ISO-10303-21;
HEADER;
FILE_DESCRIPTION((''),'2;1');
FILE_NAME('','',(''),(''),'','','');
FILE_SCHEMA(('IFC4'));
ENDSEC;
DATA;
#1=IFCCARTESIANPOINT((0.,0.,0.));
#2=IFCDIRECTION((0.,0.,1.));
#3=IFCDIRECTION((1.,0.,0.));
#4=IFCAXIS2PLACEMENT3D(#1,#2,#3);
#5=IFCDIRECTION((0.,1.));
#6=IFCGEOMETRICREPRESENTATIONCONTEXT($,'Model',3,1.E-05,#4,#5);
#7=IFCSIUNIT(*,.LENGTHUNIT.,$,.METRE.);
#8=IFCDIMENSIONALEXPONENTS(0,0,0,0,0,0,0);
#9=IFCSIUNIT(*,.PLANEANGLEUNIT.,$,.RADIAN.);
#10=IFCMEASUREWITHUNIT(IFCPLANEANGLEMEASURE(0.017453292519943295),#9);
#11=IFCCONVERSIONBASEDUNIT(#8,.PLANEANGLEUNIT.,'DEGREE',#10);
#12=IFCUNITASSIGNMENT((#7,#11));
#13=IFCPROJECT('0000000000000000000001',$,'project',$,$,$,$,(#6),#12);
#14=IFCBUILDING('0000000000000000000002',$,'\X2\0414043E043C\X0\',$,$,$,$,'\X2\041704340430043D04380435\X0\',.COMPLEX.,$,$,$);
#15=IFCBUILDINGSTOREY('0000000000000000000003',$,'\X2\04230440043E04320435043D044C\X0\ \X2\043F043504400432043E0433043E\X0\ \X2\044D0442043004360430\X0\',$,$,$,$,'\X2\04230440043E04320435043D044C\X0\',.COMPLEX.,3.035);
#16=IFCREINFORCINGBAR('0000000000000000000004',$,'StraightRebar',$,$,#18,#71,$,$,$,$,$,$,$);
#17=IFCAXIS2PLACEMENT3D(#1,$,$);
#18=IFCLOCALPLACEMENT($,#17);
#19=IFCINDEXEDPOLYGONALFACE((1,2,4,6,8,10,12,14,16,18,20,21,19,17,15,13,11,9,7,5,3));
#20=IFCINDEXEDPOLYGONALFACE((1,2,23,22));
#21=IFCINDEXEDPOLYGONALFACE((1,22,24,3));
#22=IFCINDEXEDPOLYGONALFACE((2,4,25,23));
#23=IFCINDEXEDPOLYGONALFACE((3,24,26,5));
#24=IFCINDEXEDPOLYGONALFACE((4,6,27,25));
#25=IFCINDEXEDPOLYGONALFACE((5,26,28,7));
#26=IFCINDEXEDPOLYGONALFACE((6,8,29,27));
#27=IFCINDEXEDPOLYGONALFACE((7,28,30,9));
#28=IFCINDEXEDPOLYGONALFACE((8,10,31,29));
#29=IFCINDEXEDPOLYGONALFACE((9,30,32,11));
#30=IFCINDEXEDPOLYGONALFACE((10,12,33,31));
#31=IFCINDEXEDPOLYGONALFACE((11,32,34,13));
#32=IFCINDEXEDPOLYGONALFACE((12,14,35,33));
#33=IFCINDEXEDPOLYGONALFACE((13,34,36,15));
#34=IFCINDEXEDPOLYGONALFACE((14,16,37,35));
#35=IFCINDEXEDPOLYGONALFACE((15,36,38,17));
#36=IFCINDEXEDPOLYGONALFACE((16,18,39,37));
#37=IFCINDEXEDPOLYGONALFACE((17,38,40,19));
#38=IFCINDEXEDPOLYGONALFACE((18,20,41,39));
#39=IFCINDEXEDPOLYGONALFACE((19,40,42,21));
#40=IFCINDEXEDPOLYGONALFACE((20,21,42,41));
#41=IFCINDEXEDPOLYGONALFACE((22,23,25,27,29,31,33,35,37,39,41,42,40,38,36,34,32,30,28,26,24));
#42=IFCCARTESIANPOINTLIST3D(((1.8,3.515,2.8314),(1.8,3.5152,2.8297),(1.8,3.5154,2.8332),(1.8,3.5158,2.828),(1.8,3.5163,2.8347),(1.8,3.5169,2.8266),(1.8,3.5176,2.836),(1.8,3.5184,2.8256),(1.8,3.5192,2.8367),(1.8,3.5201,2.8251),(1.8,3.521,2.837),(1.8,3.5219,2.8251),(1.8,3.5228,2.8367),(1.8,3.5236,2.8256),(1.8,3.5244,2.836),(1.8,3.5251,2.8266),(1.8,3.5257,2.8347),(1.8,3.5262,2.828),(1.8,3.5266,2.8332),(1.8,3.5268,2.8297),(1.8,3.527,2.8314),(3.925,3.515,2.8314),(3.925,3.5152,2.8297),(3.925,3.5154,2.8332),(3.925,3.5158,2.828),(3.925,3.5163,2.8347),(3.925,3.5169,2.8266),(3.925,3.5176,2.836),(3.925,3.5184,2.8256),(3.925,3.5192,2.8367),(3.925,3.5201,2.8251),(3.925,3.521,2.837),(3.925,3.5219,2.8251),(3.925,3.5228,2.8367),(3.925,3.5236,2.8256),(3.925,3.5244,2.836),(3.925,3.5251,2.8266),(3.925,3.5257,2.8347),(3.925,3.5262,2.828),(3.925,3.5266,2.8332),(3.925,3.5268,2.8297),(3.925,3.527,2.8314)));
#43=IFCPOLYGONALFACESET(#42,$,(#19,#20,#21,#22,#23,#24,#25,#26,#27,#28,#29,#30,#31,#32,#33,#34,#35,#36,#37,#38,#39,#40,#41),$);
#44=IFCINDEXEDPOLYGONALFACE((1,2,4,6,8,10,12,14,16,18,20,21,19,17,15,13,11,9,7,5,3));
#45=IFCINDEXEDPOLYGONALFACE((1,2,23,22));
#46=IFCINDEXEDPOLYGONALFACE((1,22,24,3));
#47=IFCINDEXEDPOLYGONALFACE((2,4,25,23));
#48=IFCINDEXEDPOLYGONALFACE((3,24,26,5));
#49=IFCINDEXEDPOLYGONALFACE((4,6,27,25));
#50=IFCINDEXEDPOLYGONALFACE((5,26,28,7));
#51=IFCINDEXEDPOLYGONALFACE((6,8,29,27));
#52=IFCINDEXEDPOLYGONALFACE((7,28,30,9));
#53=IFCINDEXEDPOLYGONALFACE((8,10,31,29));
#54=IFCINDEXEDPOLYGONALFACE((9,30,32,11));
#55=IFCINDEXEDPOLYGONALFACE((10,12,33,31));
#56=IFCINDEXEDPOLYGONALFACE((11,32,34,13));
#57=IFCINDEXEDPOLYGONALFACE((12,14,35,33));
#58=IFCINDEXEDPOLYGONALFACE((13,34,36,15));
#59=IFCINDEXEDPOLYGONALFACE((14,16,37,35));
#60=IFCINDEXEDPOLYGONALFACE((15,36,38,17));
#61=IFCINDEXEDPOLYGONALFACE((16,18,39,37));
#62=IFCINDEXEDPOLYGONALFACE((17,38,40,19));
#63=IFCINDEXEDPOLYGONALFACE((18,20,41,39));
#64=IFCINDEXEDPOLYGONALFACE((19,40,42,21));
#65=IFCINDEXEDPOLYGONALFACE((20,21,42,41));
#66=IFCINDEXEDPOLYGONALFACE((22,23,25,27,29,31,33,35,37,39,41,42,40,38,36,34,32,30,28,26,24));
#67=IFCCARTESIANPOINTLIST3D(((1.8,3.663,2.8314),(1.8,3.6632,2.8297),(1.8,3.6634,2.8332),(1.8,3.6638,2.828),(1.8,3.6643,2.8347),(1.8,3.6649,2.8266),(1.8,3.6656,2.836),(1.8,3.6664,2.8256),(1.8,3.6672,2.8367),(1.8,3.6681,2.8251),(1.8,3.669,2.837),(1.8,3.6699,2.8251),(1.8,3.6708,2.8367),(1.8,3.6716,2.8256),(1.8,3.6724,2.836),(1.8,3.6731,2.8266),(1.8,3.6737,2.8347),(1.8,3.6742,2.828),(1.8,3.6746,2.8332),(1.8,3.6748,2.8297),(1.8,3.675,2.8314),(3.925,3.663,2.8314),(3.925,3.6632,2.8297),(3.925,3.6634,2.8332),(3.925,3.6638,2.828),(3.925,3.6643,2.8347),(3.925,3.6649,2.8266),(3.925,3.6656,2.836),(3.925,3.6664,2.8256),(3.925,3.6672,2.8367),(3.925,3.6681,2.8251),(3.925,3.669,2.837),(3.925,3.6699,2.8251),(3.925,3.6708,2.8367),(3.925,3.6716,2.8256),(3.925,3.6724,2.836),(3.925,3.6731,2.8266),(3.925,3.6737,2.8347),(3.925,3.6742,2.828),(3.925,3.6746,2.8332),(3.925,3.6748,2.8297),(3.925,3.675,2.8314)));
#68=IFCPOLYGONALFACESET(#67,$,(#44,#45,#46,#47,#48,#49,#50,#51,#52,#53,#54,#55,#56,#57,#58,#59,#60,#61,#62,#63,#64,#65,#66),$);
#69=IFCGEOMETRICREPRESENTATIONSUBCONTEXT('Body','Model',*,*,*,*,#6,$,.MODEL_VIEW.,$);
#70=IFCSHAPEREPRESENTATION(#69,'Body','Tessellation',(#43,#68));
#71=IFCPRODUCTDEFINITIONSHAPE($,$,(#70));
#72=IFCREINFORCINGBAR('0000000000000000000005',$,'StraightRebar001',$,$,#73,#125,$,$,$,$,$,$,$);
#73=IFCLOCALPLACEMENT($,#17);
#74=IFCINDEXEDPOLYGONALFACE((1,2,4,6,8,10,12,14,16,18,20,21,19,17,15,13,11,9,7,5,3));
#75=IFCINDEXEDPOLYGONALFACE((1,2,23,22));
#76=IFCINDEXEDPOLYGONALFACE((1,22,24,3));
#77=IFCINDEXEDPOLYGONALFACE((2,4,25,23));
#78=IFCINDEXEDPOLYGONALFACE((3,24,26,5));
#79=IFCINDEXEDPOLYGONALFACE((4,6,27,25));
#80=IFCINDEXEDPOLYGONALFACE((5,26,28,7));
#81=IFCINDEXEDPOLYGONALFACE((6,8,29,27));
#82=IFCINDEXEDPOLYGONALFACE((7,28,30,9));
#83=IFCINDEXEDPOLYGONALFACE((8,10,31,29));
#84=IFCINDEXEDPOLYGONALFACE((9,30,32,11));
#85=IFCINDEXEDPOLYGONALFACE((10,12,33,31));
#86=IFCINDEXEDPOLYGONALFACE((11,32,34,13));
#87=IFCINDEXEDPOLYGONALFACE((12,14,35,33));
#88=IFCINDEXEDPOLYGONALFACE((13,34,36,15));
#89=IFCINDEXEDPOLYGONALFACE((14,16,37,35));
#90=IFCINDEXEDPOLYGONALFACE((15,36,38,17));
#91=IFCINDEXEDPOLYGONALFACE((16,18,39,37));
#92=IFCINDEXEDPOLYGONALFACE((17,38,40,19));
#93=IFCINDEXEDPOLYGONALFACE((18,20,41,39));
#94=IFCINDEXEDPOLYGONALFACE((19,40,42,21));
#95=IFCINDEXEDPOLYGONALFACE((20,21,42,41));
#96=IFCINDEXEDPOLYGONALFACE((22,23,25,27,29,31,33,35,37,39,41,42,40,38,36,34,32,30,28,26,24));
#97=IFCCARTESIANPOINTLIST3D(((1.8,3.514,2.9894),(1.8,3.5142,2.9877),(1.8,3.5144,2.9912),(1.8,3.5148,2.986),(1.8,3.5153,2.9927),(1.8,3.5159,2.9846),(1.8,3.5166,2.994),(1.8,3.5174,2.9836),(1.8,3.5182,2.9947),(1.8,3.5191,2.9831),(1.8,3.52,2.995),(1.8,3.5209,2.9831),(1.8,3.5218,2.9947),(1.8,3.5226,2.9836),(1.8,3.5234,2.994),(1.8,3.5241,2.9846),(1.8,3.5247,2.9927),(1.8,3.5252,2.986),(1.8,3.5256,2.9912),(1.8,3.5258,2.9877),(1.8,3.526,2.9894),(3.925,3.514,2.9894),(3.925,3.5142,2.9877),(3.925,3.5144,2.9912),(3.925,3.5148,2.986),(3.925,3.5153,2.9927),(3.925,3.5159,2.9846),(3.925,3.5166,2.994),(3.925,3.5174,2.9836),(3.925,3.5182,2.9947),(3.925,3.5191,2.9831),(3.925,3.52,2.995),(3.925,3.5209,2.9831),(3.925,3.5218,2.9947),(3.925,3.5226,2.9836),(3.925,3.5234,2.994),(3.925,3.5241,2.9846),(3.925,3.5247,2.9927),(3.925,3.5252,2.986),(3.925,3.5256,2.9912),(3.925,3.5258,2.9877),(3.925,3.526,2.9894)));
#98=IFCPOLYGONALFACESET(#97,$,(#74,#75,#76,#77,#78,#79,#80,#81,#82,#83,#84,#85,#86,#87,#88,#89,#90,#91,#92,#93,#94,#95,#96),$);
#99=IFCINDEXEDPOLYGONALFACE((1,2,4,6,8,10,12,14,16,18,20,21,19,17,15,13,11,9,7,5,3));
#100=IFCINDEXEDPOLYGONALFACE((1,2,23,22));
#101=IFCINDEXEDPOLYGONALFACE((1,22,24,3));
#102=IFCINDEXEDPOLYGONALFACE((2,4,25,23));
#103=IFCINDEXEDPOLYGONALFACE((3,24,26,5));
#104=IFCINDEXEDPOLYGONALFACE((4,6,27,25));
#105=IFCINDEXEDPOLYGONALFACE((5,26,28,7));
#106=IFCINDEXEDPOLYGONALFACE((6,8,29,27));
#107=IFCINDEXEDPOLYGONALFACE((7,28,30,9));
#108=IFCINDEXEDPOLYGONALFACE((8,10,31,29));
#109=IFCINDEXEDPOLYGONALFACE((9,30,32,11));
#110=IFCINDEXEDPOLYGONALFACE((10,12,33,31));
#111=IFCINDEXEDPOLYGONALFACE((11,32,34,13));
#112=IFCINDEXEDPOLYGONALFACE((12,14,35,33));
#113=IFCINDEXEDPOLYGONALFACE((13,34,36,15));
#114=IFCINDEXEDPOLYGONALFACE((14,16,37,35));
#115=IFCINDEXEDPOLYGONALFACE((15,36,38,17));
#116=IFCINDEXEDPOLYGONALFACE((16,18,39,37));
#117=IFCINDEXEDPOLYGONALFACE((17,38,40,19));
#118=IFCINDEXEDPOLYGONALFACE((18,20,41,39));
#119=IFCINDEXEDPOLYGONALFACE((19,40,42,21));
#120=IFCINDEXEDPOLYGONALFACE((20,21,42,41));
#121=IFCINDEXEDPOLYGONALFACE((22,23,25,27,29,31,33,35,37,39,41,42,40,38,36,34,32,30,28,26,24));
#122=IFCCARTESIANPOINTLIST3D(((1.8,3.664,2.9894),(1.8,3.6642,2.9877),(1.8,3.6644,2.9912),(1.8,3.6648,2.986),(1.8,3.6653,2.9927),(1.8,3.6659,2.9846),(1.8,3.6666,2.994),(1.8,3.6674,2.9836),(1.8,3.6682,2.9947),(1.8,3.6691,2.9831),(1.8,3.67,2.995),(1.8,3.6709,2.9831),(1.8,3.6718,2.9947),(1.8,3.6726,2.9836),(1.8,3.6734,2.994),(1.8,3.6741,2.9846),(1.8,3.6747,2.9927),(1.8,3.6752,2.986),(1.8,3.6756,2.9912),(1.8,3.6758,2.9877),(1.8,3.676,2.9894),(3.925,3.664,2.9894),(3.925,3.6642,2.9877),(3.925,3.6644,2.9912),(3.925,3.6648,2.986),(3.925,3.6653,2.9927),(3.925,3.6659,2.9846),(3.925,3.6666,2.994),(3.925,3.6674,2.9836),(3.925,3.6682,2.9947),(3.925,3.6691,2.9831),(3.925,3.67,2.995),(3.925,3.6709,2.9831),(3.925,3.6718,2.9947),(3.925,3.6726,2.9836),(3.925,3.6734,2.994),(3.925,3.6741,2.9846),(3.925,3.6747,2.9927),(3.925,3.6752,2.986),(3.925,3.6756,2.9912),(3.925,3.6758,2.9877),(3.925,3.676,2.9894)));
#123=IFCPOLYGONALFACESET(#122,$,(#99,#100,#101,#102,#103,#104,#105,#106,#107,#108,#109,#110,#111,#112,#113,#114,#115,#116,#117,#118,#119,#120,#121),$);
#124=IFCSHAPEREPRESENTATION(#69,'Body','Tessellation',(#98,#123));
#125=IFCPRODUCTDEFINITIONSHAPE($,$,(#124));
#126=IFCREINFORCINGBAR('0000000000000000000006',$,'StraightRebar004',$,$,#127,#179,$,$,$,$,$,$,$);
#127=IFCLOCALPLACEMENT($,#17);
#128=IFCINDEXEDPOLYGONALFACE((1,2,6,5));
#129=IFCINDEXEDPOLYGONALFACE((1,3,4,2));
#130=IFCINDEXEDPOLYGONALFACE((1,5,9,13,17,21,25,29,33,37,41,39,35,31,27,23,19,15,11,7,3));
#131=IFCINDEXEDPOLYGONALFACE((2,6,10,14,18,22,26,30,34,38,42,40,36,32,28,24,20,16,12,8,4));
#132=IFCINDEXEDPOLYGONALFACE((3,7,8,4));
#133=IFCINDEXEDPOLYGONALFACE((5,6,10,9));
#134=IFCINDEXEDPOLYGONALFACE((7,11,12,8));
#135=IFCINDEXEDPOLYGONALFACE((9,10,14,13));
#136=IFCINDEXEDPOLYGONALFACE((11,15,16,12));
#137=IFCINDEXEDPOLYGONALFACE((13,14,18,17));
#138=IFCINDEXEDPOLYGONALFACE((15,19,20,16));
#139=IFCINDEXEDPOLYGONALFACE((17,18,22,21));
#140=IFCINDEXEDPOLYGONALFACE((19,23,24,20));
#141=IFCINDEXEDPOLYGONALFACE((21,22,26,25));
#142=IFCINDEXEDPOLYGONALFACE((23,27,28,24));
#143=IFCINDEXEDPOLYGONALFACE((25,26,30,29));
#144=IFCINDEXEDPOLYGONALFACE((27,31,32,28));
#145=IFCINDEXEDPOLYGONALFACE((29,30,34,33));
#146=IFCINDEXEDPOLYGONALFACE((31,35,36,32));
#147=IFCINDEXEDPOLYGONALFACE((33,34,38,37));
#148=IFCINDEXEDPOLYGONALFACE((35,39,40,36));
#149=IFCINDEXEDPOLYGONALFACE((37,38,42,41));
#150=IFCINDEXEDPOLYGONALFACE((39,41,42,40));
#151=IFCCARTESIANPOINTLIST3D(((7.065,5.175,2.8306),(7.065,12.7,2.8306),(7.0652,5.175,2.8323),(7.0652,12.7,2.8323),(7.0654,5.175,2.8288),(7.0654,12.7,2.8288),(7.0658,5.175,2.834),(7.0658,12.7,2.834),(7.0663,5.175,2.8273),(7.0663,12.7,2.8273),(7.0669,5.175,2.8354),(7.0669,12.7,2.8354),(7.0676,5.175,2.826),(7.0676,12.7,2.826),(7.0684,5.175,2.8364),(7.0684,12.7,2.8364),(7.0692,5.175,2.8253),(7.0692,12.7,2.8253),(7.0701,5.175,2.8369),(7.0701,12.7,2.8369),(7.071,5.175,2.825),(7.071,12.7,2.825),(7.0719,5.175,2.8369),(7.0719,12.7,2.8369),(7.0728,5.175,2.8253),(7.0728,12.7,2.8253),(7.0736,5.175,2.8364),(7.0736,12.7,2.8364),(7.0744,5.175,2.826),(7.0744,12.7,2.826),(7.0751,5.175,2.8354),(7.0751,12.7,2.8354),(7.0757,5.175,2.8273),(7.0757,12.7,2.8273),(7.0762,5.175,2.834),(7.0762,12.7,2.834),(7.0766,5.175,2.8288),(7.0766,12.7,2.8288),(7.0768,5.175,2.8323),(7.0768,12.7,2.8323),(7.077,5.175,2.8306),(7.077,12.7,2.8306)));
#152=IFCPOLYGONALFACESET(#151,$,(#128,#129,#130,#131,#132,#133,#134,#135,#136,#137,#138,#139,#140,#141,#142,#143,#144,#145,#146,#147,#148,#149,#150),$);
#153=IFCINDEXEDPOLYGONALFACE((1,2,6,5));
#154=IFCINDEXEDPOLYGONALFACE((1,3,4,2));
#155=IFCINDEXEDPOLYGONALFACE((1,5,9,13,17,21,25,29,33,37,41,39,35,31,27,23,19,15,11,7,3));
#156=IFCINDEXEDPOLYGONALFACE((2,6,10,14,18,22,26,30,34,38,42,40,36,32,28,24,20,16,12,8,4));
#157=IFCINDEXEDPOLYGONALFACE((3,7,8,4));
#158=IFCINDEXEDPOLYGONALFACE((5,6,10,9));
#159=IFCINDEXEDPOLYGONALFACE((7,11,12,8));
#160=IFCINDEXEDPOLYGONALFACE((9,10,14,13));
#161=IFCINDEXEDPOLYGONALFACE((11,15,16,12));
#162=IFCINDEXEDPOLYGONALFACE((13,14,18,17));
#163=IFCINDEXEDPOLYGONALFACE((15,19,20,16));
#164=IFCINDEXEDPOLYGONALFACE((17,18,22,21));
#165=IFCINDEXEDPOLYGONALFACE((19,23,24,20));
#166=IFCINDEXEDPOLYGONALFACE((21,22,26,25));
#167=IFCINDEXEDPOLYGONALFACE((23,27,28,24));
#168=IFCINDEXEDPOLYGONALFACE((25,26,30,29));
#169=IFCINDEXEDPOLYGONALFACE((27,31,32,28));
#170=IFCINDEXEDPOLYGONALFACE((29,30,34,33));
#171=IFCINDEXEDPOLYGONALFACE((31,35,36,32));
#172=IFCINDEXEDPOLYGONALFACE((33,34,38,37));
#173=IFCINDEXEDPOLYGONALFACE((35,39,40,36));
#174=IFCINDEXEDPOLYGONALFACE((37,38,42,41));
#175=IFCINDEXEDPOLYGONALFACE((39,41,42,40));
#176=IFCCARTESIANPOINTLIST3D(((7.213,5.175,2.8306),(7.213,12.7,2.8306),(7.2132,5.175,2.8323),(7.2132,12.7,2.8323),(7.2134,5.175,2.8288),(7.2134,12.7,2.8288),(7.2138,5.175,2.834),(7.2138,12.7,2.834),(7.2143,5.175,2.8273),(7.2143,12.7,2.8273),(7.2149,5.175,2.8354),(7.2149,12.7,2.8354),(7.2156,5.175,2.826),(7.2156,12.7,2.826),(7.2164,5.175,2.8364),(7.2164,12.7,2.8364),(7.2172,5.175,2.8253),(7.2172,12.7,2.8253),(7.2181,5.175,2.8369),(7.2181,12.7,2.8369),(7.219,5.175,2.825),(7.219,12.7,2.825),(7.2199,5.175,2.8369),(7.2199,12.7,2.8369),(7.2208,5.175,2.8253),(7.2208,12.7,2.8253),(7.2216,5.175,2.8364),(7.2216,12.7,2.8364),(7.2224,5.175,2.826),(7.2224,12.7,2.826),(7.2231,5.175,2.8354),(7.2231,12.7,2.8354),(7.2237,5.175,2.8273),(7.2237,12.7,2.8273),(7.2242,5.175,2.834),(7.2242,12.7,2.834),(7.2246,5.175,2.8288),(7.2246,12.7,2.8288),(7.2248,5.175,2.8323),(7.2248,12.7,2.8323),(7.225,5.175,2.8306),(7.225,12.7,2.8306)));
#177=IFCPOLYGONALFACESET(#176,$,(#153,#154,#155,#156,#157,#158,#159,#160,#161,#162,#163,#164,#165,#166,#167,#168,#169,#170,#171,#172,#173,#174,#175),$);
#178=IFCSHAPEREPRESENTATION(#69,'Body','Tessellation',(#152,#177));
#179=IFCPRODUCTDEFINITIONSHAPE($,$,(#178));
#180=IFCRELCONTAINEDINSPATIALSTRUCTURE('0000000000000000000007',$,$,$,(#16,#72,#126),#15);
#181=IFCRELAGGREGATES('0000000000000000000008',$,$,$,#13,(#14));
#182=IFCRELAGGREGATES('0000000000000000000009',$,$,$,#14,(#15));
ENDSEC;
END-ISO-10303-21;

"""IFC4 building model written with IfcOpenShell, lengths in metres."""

from ifc_helpers import new_model, entity, si_unit, converted_unit, direction, origin_with_axes, place, context, subcontext, project, spatial, element, save


model = new_model("IFC4")

# Units and contexts
model_context = context("Model", 3, precision=1e-05, world=origin_with_axes(), true_north=direction((0.0, 1.0)))
body_context = subcontext(model_context, "Body", "Model", "MODEL_VIEW")
ifc_project = project(units=[si_unit("LENGTHUNIT", "METRE"), converted_unit("PLANEANGLEUNIT", "DEGREE", entity("IfcPlaneAngleMeasure", 0.017453292519943295), si_unit("PLANEANGLEUNIT", "RADIAN"), dimensions=[0, 0, 0, 0, 0, 0, 0])], contexts=[model_context])

# Building, storey
building = spatial("IfcBuilding", under=ifc_project, Name="Дом", LongName="Здание", CompositionType="COMPLEX")
storey = spatial("IfcBuildingStorey", under=building, Name="Уровень первого этажа", LongName="Уровень", CompositionType="COMPLEX", Elevation=3.035)

# Shared definitions
placement = place(None, origin_with_axes())

# Reinforcing bars
element("IfcReinforcingBar", 1, at=placement, inside=storey, Name="StraightRebar", context=body_context, shape_type="SweptSolid", body=[
    entity("IfcSweptDiskSolid", entity("IfcCompositeCurve", [entity("IfcCompositeCurveSegment", "CONTINUOUS", True, entity("IfcPolyline", [entity("IfcCartesianPoint", [1.8, 3.521, 2.831]), entity("IfcCartesianPoint", [3.925, 3.521, 2.831])]))], False), 0.006),
    entity("IfcSweptDiskSolid", entity("IfcCompositeCurve", [entity("IfcCompositeCurveSegment", "CONTINUOUS", True, entity("IfcPolyline", [entity("IfcCartesianPoint", [1.8, 3.669, 2.831]), entity("IfcCartesianPoint", [3.925, 3.669, 2.831])]))], False), 0.006),
])
element("IfcReinforcingBar", 2, at=placement, inside=storey, Name="StraightRebar001", context=body_context, shape_type="SweptSolid", body=[
    entity("IfcSweptDiskSolid", entity("IfcCompositeCurve", [entity("IfcCompositeCurveSegment", "CONTINUOUS", True, entity("IfcPolyline", [entity("IfcCartesianPoint", [1.8, 3.52, 2.989]), entity("IfcCartesianPoint", [3.925, 3.52, 2.989])]))], False), 0.006),
    entity("IfcSweptDiskSolid", entity("IfcCompositeCurve", [entity("IfcCompositeCurveSegment", "CONTINUOUS", True, entity("IfcPolyline", [entity("IfcCartesianPoint", [1.8, 3.67, 2.989]), entity("IfcCartesianPoint", [3.925, 3.67, 2.989])]))], False), 0.006),
])
element("IfcReinforcingBar", 3, at=placement, inside=storey, Name="StraightRebar004", context=body_context, shape_type="SweptSolid", body=[
    entity("IfcSweptDiskSolid", entity("IfcCompositeCurve", [entity("IfcCompositeCurveSegment", "CONTINUOUS", True, entity("IfcPolyline", [entity("IfcCartesianPoint", [7.071, 12.7, 2.831]), entity("IfcCartesianPoint", [7.071, 5.175, 2.831])]))], False), 0.006),
    entity("IfcSweptDiskSolid", entity("IfcCompositeCurve", [entity("IfcCompositeCurveSegment", "CONTINUOUS", True, entity("IfcPolyline", [entity("IfcCartesianPoint", [7.219, 12.7, 2.831]), entity("IfcCartesianPoint", [7.219, 5.175, 2.831])]))], False), 0.006),
])

save(model, "model.ifc")
